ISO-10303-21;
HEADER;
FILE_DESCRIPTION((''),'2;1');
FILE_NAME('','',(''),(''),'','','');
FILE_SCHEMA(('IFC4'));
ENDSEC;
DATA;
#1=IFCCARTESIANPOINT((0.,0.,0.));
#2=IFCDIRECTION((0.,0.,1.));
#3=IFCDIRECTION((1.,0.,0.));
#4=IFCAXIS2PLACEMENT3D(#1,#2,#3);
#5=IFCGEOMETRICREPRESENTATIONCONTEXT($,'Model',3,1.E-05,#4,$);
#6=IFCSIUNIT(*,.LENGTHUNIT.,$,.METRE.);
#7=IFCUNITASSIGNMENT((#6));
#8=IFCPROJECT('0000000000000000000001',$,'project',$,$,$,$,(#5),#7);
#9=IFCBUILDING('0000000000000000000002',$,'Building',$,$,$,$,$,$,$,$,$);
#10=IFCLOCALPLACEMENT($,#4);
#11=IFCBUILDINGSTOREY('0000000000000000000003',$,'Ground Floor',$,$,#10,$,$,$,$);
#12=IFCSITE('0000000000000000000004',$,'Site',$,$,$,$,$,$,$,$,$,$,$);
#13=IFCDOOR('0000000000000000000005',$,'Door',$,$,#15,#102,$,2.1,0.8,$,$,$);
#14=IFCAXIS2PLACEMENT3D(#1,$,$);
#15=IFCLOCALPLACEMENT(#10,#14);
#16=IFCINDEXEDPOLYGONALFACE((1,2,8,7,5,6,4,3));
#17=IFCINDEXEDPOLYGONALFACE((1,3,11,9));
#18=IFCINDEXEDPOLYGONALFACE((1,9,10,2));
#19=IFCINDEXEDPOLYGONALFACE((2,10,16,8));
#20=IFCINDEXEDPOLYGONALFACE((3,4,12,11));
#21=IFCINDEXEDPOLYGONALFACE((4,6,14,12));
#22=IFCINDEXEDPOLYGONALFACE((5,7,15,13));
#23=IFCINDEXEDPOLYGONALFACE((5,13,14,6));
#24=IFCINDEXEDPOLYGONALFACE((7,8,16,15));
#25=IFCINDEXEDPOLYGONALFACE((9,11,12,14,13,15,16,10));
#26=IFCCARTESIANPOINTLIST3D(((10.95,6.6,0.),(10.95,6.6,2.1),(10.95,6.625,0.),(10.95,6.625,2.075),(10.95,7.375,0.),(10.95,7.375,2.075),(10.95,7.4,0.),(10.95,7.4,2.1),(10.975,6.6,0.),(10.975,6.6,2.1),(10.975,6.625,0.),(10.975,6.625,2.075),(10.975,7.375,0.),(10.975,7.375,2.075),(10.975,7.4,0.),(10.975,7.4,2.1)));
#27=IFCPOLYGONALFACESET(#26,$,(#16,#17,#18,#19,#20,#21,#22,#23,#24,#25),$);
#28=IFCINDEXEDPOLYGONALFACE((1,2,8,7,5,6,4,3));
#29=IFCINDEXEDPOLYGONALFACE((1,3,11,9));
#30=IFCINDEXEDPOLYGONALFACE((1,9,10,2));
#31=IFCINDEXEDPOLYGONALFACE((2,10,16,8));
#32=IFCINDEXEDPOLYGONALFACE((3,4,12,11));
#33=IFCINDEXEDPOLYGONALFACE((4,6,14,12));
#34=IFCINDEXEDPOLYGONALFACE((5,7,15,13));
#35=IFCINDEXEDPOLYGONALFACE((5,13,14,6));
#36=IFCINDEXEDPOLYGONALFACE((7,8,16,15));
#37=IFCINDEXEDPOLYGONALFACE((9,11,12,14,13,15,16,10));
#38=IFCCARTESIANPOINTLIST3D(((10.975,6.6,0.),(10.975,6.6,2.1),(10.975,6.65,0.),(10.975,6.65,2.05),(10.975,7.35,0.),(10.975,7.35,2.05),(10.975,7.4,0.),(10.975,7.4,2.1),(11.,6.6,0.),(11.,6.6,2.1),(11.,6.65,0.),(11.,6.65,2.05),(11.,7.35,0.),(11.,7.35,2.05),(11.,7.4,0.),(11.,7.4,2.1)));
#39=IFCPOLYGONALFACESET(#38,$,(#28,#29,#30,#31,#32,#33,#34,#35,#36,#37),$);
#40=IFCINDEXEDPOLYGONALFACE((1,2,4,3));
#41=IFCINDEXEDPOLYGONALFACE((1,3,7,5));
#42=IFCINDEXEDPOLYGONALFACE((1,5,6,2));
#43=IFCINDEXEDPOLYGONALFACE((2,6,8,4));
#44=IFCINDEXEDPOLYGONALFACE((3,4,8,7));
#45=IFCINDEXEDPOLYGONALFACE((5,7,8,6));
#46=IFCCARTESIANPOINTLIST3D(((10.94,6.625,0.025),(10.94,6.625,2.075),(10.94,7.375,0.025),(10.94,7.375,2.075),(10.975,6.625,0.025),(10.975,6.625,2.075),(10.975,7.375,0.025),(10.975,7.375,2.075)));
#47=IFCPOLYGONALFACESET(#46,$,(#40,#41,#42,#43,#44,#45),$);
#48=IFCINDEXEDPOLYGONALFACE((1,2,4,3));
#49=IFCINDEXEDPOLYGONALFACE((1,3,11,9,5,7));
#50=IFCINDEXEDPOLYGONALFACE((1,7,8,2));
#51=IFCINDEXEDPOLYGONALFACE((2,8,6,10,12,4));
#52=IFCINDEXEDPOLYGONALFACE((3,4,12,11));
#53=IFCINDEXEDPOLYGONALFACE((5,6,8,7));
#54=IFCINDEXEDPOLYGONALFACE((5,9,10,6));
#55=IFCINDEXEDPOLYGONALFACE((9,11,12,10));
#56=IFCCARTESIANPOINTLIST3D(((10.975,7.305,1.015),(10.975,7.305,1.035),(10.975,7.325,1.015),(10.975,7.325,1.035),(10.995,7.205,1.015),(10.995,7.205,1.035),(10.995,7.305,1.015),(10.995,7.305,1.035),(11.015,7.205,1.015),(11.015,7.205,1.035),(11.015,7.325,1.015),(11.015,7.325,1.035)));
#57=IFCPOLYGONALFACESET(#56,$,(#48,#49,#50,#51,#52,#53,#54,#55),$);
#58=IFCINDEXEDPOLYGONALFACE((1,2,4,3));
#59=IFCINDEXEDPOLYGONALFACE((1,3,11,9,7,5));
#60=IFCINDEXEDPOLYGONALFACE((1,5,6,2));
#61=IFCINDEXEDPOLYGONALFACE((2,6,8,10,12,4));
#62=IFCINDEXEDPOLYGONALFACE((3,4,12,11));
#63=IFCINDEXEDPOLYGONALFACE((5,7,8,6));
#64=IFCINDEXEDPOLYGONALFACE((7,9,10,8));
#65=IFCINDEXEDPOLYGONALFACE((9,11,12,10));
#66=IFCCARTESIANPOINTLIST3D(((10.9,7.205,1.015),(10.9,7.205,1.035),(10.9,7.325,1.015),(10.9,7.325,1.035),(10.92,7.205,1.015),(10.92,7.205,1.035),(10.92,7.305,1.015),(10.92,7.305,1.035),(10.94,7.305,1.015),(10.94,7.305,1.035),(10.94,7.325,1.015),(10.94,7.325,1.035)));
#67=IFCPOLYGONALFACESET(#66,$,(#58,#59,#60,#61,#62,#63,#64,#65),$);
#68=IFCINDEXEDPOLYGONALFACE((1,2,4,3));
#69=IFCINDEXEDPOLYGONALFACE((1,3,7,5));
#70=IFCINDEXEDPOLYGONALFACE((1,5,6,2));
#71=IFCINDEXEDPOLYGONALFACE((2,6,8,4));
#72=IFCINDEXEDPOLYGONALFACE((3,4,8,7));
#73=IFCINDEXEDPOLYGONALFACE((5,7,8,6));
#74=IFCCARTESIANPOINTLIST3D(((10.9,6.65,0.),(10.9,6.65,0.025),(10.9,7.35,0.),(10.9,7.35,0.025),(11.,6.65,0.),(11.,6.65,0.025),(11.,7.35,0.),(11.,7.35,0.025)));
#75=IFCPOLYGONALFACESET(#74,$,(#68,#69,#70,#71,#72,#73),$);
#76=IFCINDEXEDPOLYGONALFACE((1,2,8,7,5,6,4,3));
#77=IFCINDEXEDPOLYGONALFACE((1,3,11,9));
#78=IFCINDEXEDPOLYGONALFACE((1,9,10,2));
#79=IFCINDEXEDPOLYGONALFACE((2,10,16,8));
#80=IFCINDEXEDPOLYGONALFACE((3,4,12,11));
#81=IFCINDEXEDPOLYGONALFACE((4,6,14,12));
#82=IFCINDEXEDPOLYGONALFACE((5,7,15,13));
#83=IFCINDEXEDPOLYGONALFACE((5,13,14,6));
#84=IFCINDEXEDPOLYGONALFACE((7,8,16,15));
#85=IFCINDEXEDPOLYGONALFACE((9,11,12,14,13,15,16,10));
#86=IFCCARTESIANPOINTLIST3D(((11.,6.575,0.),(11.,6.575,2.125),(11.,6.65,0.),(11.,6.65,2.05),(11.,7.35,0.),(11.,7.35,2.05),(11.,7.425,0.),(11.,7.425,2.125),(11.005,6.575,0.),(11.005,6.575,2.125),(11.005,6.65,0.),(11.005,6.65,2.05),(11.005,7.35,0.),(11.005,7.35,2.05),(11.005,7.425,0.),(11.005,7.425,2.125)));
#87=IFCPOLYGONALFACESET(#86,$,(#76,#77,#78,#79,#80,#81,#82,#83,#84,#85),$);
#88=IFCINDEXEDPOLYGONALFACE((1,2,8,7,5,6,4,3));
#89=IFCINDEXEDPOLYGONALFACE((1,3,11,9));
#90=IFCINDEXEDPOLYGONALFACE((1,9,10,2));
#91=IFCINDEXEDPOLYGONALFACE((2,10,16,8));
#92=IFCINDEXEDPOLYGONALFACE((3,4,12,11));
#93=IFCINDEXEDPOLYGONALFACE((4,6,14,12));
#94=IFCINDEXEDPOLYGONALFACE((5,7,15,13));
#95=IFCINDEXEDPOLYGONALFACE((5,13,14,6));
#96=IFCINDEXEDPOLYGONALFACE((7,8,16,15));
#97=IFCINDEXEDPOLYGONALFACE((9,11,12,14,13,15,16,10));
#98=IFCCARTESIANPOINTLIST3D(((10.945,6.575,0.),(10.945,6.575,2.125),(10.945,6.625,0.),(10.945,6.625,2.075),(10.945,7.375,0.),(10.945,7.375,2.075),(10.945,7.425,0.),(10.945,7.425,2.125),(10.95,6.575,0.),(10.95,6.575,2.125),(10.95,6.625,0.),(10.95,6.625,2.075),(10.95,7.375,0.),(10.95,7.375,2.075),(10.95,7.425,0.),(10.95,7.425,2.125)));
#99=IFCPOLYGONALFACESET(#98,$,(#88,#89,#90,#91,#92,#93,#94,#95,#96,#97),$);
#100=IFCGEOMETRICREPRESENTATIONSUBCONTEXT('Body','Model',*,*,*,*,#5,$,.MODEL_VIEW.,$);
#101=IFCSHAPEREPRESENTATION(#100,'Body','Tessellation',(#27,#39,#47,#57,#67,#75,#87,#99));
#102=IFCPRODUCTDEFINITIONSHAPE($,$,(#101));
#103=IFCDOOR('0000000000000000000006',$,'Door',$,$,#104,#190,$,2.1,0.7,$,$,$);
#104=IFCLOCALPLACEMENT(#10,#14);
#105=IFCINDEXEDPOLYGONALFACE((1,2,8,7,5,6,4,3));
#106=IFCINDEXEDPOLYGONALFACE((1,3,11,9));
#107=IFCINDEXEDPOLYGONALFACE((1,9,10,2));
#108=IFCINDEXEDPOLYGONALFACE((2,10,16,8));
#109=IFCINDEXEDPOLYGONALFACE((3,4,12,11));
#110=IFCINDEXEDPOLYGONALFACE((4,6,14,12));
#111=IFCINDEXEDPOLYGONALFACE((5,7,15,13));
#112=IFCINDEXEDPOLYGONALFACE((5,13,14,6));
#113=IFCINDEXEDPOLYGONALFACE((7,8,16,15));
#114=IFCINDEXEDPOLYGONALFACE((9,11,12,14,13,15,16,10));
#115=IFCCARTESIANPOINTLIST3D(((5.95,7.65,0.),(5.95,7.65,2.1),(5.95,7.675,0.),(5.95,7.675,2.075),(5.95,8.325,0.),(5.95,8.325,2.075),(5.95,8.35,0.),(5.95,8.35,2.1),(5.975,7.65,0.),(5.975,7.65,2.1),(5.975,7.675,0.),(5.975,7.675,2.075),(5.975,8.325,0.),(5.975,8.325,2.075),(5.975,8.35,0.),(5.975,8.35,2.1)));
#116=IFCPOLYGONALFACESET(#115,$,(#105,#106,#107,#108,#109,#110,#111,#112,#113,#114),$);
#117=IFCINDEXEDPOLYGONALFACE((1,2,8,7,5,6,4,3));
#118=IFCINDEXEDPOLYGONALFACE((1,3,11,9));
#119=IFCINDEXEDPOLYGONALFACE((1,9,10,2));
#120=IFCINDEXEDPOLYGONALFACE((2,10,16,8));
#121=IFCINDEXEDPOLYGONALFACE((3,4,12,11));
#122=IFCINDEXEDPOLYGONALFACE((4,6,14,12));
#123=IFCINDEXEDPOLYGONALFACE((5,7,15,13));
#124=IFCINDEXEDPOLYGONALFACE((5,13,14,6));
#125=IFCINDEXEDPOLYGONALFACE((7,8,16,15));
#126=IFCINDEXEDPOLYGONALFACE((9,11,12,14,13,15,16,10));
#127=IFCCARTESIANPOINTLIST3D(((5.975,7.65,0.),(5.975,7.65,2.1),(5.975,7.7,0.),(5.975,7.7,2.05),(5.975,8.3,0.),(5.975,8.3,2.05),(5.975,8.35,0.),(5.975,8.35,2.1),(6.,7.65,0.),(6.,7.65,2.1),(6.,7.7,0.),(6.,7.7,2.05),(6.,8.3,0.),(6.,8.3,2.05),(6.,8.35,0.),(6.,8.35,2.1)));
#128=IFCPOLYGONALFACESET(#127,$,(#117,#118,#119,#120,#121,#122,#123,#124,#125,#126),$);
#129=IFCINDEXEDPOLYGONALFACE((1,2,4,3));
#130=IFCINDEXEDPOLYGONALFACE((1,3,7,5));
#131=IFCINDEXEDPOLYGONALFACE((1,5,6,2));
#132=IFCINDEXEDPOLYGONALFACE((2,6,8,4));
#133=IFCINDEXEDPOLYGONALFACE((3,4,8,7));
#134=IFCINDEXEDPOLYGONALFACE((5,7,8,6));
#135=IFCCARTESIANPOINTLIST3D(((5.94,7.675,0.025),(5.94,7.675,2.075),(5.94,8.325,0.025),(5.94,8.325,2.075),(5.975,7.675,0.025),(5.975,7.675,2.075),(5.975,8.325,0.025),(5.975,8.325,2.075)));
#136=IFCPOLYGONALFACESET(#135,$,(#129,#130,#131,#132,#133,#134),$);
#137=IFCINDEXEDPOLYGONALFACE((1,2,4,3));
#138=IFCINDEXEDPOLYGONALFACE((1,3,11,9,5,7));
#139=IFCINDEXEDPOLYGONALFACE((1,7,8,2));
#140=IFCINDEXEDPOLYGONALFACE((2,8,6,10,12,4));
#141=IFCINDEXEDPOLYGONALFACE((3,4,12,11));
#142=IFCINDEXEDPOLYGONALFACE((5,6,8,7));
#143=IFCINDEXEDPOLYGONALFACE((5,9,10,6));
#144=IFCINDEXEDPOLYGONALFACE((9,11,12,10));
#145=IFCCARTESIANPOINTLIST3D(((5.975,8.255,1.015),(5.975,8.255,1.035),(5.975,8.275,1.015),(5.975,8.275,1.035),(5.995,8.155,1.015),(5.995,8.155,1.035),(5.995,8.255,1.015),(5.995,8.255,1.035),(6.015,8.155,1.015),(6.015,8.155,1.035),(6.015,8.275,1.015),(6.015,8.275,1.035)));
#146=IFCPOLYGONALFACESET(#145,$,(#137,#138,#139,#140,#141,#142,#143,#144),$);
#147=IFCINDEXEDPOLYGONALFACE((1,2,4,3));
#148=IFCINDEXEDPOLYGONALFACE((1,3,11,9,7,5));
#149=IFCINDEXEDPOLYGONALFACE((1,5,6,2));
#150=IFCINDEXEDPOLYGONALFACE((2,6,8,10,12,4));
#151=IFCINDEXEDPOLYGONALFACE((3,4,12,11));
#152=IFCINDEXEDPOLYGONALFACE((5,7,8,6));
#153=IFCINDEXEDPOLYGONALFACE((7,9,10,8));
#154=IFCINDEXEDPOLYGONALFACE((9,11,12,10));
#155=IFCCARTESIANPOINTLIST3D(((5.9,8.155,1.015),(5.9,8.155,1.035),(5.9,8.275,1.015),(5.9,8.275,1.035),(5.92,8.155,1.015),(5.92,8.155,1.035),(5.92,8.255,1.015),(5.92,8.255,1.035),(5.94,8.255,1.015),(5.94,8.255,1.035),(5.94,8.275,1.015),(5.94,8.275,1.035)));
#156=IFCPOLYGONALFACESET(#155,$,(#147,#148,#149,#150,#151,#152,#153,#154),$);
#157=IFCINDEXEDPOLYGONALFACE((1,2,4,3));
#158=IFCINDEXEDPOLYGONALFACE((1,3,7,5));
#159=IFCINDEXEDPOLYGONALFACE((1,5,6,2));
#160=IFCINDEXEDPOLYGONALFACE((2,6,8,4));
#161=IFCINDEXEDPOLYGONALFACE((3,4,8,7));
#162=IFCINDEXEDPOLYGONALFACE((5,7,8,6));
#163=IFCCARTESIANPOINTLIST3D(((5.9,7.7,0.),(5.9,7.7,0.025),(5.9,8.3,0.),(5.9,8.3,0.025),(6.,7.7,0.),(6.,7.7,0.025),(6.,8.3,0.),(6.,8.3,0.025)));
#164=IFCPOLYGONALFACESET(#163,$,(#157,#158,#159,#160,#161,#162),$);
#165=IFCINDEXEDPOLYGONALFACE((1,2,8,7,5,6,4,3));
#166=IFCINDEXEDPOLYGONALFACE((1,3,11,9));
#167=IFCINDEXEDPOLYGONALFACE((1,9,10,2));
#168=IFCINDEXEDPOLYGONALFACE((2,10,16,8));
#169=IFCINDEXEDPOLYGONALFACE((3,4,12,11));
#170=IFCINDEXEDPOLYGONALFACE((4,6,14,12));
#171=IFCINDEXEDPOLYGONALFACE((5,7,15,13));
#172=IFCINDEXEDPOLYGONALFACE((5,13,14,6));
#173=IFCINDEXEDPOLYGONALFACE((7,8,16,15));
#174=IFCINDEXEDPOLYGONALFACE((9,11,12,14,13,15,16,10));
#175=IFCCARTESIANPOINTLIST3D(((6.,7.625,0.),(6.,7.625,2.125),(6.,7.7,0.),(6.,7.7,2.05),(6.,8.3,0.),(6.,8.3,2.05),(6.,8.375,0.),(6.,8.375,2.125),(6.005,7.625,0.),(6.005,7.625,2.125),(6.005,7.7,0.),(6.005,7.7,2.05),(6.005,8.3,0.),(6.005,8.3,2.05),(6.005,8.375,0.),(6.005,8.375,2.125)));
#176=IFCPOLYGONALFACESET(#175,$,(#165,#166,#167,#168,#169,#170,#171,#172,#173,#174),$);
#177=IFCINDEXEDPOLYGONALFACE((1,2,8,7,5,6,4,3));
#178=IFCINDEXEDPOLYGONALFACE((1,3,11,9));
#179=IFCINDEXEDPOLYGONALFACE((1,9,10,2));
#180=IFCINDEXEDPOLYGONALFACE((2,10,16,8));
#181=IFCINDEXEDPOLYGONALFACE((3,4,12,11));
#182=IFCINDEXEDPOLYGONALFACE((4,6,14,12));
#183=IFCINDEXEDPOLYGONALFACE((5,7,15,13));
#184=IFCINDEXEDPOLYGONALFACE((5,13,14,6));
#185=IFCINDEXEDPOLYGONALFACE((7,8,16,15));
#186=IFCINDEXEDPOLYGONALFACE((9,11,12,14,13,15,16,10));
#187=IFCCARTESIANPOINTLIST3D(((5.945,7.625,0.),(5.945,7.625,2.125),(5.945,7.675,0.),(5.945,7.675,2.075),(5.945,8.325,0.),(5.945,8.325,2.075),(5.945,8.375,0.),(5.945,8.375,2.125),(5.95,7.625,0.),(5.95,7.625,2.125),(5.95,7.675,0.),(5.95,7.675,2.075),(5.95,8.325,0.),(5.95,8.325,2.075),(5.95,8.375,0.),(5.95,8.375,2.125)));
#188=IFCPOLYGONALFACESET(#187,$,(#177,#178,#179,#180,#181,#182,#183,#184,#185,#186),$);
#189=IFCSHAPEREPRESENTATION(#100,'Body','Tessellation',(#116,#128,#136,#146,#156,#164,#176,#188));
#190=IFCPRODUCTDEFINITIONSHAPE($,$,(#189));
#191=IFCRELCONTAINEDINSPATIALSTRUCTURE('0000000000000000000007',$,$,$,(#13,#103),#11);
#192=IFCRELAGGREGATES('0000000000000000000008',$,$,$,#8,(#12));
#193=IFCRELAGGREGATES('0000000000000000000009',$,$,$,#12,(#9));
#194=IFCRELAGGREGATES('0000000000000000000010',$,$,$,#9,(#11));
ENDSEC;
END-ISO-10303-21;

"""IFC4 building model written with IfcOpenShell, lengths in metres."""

from ifc_helpers import new_model, si_unit, frame, origin_with_axes, place, context, subcontext, project, spatial, line, indexed_curve, outline, extrude, element, save


model = new_model("IFC4")

# Units and contexts
model_context = context("Model", 3, precision=1e-05, world=origin_with_axes())
body_context = subcontext(model_context, "Body", "Model", "MODEL_VIEW")
ifc_project = project(units=[si_unit("LENGTHUNIT", "METRE")], contexts=[model_context])

# Site, building, storey
site = spatial("IfcSite", under=ifc_project, Name="Site")
building = spatial("IfcBuilding", under=site, Name="Building")
storey_placement = place(None, origin_with_axes())
storey = spatial("IfcBuildingStorey", under=building, at=storey_placement, Name="Ground Floor")

# Doors
door_1_placement = place(storey_placement, frame((11.0, 6.6, 0.0), z_axis=(0.0, 0.0, 1.0), x_axis=(0.0, 1.0, 0.0)))
element("IfcDoor", 1, at=door_1_placement, inside=storey, Name="Door", OverallHeight=2.1, OverallWidth=0.8, context=body_context, shape_type="SweptSolid", body=[
    extrude(outline(indexed_curve([(0.0, 0.0), (0.0, 2.1), (0.8, 2.1), (0.8, 0.0), (0.775, 0.0), (0.775, 2.075), (0.025, 2.075), (0.025, 0.0)], segments=[line(1, 2, 3, 4, 5, 6, 7, 8, 1)])), frame((0.0, 0.025, 0.0), z_axis=(0.0, -1.0, 0.0), x_axis=(1.0, 0.0, 0.0)), (0.0, 0.0, -1.0), 0.025),
    extrude(outline(indexed_curve([(0.0, 0.0), (0.0, 2.1), (0.8, 2.1), (0.8, 0.0), (0.75, 0.0), (0.75, 2.05), (0.05, 2.05), (0.05, 0.0)], segments=[line(1, 2, 3, 4, 5, 6, 7, 8, 1)])), frame((0.0, 0.0, 0.0), z_axis=(0.0, -1.0, 0.0), x_axis=(1.0, 0.0, 0.0)), (0.0, 0.0, -1.0), 0.025),
    extrude(outline(indexed_curve([(0.0, 0.0), (0.75, 0.0), (0.75, 0.035), (0.0, 0.035)], segments=[line(1, 2, 3, 4, 1)])), frame((0.025, 0.025, 0.025), z_axis=(0.0, 0.0, 1.0), x_axis=(1.0, 0.0, 0.0)), (0.0, 0.0, 1.0), 2.05),
    extrude(outline(indexed_curve([(0.0, 0.0), (0.0, -0.04), (-0.12, -0.04), (-0.12, -0.02), (-0.02, -0.02), (-0.02, 0.0)], segments=[line(1, 2, 3, 4, 5, 6, 1)])), frame((0.725, 0.025, 1.015), z_axis=(0.0, 0.0, 1.0), x_axis=(1.0, 0.0, 0.0)), (0.0, 0.0, 1.0), 0.02),
    extrude(outline(indexed_curve([(0.0, 0.0), (0.0, 0.04), (-0.12, 0.04), (-0.12, 0.02), (-0.02, 0.02), (-0.02, 0.0)], segments=[line(1, 2, 3, 4, 5, 6, 1)])), frame((0.725, 0.06, 1.015), z_axis=(0.0, 0.0, 1.0), x_axis=(1.0, 0.0, 0.0)), (0.0, 0.0, 1.0), 0.02),
    extrude(outline(indexed_curve([(0.0, 0.0), (0.7, 0.0), (0.7, 0.1), (0.0, 0.1)], segments=[line(1, 2, 3, 4, 1)])), frame((0.05, 0.0, 0.0), z_axis=(0.0, 0.0, 1.0), x_axis=(1.0, 0.0, 0.0)), (0.0, 0.0, 1.0), 0.025),
    extrude(outline(indexed_curve([(0.0, 0.0), (0.0, 2.125), (0.85, 2.125), (0.85, 0.0), (0.775, 0.0), (0.775, 2.05), (0.075, 2.05), (0.075, 0.0)], segments=[line(1, 2, 3, 4, 5, 6, 7, 8, 1)])), frame((-0.025, -0.005, 0.0), z_axis=(0.0, -1.0, 0.0), x_axis=(1.0, 0.0, 0.0)), (0.0, 0.0, -1.0), 0.005),
    extrude(outline(indexed_curve([(0.0, 0.0), (0.0, 2.125), (0.85, 2.125), (0.85, 0.0), (0.8, 0.0), (0.8, 2.075), (0.05, 2.075), (0.05, 0.0)], segments=[line(1, 2, 3, 4, 5, 6, 7, 8, 1)])), frame((-0.025, 0.05, 0.0), z_axis=(0.0, -1.0, 0.0), x_axis=(1.0, 0.0, 0.0)), (0.0, 0.0, -1.0), 0.005),
])
door_2_placement = place(storey_placement, frame((6.0, 7.65, 0.0), z_axis=(0.0, 0.0, 1.0), x_axis=(0.0, 1.0, 0.0)))
element("IfcDoor", 2, at=door_2_placement, inside=storey, Name="Door", OverallHeight=2.1, OverallWidth=0.7, context=body_context, shape_type="SweptSolid", body=[
    extrude(outline(indexed_curve([(0.0, 0.0), (0.0, 2.1), (0.7, 2.1), (0.7, 0.0), (0.675, 0.0), (0.675, 2.075), (0.025, 2.075), (0.025, 0.0)], segments=[line(1, 2, 3, 4, 5, 6, 7, 8, 1)])), frame((0.0, 0.025, 0.0), z_axis=(0.0, -1.0, 0.0), x_axis=(1.0, 0.0, 0.0)), (0.0, 0.0, -1.0), 0.025),
    extrude(outline(indexed_curve([(0.0, 0.0), (0.0, 2.1), (0.7, 2.1), (0.7, 0.0), (0.65, 0.0), (0.65, 2.05), (0.05, 2.05), (0.05, 0.0)], segments=[line(1, 2, 3, 4, 5, 6, 7, 8, 1)])), frame((0.0, 0.0, 0.0), z_axis=(0.0, -1.0, 0.0), x_axis=(1.0, 0.0, 0.0)), (0.0, 0.0, -1.0), 0.025),
    extrude(outline(indexed_curve([(0.0, 0.0), (0.65, 0.0), (0.65, 0.035), (0.0, 0.035)], segments=[line(1, 2, 3, 4, 1)])), frame((0.025, 0.025, 0.025), z_axis=(0.0, 0.0, 1.0), x_axis=(1.0, 0.0, 0.0)), (0.0, 0.0, 1.0), 2.05),
    extrude(outline(indexed_curve([(0.0, 0.0), (0.0, -0.04), (-0.12, -0.04), (-0.12, -0.02), (-0.02, -0.02), (-0.02, 0.0)], segments=[line(1, 2, 3, 4, 5, 6, 1)])), frame((0.625, 0.025, 1.015), z_axis=(0.0, 0.0, 1.0), x_axis=(1.0, 0.0, 0.0)), (0.0, 0.0, 1.0), 0.02),
    extrude(outline(indexed_curve([(0.0, 0.0), (0.0, 0.04), (-0.12, 0.04), (-0.12, 0.02), (-0.02, 0.02), (-0.02, 0.0)], segments=[line(1, 2, 3, 4, 5, 6, 1)])), frame((0.625, 0.06, 1.015), z_axis=(0.0, 0.0, 1.0), x_axis=(1.0, 0.0, 0.0)), (0.0, 0.0, 1.0), 0.02),
    extrude(outline(indexed_curve([(0.0, 0.0), (0.6, 0.0), (0.6, 0.1), (0.0, 0.1)], segments=[line(1, 2, 3, 4, 1)])), frame((0.05, 0.0, 0.0), z_axis=(0.0, 0.0, 1.0), x_axis=(1.0, 0.0, 0.0)), (0.0, 0.0, 1.0), 0.025),
    extrude(outline(indexed_curve([(0.0, 0.0), (0.0, 2.125), (0.75, 2.125), (0.75, 0.0), (0.675, 0.0), (0.675, 2.05), (0.075, 2.05), (0.075, 0.0)], segments=[line(1, 2, 3, 4, 5, 6, 7, 8, 1)])), frame((-0.025, -0.005, 0.0), z_axis=(0.0, -1.0, 0.0), x_axis=(1.0, 0.0, 0.0)), (0.0, 0.0, -1.0), 0.005),
    extrude(outline(indexed_curve([(0.0, 0.0), (0.0, 2.125), (0.75, 2.125), (0.75, 0.0), (0.7, 0.0), (0.7, 2.075), (0.05, 2.075), (0.05, 0.0)], segments=[line(1, 2, 3, 4, 5, 6, 7, 8, 1)])), frame((-0.025, 0.05, 0.0), z_axis=(0.0, -1.0, 0.0), x_axis=(1.0, 0.0, 0.0)), (0.0, 0.0, -1.0), 0.005),
])

save(model, "model.ifc")
